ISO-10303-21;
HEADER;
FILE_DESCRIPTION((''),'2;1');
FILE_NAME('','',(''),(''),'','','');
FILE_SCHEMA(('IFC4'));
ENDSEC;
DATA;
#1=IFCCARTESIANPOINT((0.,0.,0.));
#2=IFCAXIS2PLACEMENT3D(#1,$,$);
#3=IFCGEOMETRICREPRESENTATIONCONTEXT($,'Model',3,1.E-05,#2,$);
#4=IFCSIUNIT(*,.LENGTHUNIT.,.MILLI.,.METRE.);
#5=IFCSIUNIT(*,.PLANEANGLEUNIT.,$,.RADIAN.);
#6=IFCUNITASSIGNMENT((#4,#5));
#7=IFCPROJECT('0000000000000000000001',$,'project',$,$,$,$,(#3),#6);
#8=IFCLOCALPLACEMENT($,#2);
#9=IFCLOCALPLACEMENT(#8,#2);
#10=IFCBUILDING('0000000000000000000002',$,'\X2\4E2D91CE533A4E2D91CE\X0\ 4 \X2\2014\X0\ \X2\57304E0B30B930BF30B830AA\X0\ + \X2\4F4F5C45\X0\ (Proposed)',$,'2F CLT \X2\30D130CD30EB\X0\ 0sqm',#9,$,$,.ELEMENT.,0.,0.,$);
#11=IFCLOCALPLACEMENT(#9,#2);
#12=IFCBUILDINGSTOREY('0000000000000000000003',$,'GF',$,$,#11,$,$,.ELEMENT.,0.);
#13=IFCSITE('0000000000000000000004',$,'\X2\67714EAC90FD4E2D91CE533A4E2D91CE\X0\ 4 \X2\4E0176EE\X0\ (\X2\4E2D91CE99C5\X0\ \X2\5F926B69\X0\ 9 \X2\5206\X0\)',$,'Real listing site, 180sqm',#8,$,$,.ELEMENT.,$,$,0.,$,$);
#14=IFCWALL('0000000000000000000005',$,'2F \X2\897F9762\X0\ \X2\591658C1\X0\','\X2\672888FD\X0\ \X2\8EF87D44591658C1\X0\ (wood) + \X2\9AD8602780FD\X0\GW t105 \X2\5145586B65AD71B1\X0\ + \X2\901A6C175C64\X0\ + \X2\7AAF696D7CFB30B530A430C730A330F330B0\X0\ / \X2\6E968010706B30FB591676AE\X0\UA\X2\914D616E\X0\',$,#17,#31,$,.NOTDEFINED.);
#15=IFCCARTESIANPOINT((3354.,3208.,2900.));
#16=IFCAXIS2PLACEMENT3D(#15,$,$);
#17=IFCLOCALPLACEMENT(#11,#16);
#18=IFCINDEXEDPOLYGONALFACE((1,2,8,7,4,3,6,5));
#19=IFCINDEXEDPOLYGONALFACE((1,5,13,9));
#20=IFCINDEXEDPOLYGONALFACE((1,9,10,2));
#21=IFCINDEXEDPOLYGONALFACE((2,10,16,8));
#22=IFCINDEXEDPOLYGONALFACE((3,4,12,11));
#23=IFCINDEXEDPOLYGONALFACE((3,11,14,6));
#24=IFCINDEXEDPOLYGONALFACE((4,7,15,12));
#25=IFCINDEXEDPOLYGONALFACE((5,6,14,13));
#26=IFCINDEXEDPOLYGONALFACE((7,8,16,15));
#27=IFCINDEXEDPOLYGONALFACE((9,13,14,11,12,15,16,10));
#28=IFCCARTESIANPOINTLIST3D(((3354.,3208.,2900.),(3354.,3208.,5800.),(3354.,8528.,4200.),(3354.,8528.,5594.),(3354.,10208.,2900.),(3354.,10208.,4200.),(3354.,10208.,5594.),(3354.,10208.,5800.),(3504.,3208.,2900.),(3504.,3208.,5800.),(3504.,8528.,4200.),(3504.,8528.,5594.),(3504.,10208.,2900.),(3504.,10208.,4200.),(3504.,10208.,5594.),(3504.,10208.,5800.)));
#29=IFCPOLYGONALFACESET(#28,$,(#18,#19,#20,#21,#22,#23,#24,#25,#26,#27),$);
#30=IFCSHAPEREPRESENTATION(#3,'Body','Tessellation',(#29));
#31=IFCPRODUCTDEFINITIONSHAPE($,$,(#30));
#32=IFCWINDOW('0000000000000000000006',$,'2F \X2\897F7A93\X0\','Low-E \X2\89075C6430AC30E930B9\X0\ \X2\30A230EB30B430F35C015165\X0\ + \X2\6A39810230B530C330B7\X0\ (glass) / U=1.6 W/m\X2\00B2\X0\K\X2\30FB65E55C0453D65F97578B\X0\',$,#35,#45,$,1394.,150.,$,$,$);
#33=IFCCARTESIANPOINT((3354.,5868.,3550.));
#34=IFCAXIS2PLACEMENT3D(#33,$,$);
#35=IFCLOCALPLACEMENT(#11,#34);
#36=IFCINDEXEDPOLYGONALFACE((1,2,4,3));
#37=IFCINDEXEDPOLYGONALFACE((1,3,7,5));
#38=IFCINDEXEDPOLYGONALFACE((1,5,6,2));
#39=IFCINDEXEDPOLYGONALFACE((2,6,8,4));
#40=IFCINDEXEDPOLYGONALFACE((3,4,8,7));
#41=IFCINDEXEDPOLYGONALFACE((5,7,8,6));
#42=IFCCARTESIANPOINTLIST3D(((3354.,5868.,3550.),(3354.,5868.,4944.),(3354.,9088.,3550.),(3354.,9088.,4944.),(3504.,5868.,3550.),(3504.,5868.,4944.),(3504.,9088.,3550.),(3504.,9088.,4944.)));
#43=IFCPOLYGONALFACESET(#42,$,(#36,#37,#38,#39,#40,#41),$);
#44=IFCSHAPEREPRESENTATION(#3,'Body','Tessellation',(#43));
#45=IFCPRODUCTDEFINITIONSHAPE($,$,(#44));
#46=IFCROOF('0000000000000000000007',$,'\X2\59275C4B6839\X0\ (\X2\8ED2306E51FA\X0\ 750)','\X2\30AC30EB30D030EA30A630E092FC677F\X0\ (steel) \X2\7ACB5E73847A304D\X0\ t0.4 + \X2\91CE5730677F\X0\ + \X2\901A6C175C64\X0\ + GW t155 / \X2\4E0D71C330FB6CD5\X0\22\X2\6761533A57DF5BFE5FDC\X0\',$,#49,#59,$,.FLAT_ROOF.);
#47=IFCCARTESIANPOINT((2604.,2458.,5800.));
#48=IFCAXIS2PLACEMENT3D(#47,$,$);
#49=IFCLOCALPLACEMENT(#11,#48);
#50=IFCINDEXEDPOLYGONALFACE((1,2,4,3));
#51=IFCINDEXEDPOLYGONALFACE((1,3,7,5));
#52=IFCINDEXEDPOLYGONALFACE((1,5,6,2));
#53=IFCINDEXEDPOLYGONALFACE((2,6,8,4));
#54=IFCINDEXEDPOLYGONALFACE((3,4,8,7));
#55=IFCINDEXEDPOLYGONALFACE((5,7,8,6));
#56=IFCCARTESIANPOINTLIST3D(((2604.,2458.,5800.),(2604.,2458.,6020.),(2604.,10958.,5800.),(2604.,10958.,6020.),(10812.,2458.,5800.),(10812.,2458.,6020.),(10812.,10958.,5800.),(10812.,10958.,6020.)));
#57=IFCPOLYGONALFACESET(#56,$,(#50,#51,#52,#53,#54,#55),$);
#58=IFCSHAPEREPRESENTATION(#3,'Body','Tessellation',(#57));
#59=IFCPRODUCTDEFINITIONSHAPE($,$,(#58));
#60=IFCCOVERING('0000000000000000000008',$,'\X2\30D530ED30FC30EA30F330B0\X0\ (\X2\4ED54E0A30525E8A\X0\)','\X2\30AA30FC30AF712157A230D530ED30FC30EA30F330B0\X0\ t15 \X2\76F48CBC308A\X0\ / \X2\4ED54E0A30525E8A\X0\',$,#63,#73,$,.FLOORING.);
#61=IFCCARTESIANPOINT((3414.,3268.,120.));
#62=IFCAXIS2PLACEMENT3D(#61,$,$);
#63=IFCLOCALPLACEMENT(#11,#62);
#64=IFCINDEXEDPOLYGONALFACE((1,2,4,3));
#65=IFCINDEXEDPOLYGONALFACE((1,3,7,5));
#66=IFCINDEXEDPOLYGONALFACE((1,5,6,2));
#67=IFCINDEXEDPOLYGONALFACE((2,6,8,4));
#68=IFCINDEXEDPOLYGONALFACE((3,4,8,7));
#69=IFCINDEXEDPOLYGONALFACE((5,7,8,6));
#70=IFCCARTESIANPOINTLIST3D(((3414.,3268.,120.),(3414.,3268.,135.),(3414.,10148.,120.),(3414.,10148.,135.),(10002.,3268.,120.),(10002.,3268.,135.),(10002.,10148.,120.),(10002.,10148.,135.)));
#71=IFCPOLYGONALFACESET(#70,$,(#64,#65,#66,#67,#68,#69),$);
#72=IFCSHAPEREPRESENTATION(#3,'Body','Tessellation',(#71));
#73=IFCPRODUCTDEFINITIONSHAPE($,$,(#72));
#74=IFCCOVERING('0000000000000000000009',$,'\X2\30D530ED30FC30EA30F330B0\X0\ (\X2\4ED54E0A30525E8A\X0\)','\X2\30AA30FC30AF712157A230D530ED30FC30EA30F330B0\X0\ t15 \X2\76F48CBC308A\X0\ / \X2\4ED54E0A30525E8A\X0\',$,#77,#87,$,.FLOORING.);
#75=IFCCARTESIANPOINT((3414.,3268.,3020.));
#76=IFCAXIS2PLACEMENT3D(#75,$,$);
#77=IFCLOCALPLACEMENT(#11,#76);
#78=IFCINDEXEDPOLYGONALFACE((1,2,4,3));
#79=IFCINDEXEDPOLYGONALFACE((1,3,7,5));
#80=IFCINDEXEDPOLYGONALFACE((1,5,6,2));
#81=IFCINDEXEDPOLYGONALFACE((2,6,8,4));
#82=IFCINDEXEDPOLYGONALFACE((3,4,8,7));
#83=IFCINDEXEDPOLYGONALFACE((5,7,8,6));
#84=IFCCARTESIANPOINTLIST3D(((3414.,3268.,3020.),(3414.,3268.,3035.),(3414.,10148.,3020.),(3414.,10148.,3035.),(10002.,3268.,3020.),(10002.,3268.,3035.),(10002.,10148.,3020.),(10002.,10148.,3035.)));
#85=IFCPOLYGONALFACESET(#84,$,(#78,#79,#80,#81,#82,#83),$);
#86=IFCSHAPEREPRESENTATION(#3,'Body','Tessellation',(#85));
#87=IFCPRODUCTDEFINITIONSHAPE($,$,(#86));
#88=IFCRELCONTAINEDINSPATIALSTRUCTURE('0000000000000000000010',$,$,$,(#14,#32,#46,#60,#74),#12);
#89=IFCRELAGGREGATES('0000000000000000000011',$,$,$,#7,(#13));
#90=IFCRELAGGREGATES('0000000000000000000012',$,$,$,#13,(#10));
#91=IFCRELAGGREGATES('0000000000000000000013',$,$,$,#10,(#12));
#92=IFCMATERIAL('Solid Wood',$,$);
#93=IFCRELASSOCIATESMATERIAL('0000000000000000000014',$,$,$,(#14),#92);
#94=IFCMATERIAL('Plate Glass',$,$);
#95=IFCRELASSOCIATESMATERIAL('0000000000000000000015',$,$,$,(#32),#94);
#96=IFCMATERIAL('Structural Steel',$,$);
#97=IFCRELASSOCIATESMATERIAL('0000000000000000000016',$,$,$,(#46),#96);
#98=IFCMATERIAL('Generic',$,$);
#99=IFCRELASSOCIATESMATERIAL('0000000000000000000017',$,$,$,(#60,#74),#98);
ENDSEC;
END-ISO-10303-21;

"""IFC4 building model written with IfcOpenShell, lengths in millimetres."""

from ifc_helpers import new_model, si_unit, frame, frame_2d, origin, place, context, project, spatial, rectangle, extrude, material, element, fill, save


model = new_model("IFC4")

# Units and contexts
model_context = context("Model", 3, precision=1e-05, world=origin())
ifc_project = project(units=[si_unit("LENGTHUNIT", "METRE", prefix="MILLI"), si_unit("PLANEANGLEUNIT", "RADIAN")], contexts=[model_context])

# Site, building, storey
site_placement = place(None, origin())
site = spatial("IfcSite", under=ifc_project, at=site_placement, Name="東京都中野区中野 4 丁目 (中野駅 徒歩 9 分)", ObjectType="Real listing site, 180sqm", CompositionType="ELEMENT", RefElevation=0.0)
building_placement = place(site_placement, origin())
building = spatial("IfcBuilding", under=site, at=building_placement, Name="中野区中野 4 — 地下スタジオ + 住居 (Proposed)", ObjectType="2F CLT パネル 0sqm", CompositionType="ELEMENT", ElevationOfRefHeight=0.0, ElevationOfTerrain=0.0)
storey_placement = place(building_placement, origin())
storey = spatial("IfcBuildingStorey", under=building, at=storey_placement, Name="GF", CompositionType="ELEMENT", Elevation=0.0)

# Shared definitions
ifc_material_1 = material(Name="Solid Wood")

# Shared definitions
ifc_material_2 = material(Name="Plate Glass")

# Wall, opening, window
wall_1_placement = place(storey_placement, frame((3354.0, 3208.0, 2900.0)))
wall_1 = element("IfcWall", 1, at=wall_1_placement, inside=storey, material=ifc_material_1, Name="2F 西面 外壁", Description="木製 軸組外壁 (wood) + 高性能GW t105 充填断熱 + 通気層 + 窯業系サイディング / 準耐火・外皮UA配慮", PredefinedType="NOTDEFINED", context=model_context, shape_type="SweptSolid", body=[
    extrude(rectangle(XDim=150.0, YDim=7000.0, at=frame_2d((75.0, 3500.0))), frame((3354.0, 3208.0, 2900.0)), (0.0, 0.0, 1.0), 2900.0),
])
opening_1_placement = place(storey_placement, frame((3354.0, 5868.0, 3550.0)))
opening_1 = element("IfcOpeningElement", 2, at=opening_1_placement, cuts=wall_1, PredefinedType="NOTDEFINED", context=model_context, shape_type="SweptSolid", body=[
    extrude(rectangle(XDim=150.0, YDim=3220.0, at=frame_2d((75.0, 1610.0))), frame((3354.0, 5868.0, 3550.0)), (0.0, 0.0, 1.0), 1394.0),
])
window_1_placement = place(storey_placement, frame((3354.0, 5868.0, 3550.0)))
window_1 = element("IfcWindow", 3, at=window_1_placement, inside=storey, material=ifc_material_2, Name="2F 西窓", Description="Low-E 複層ガラス アルゴン封入 + 樹脂サッシ (glass) / U=1.6 W/m²K・日射取得型", OverallHeight=1394.0, OverallWidth=150.0, context=model_context, shape_type="SweptSolid", body=[
    extrude(rectangle(XDim=150.0, YDim=3220.0, at=frame_2d((75.0, 1610.0))), frame((3354.0, 5868.0, 3550.0)), (0.0, 0.0, 1.0), 1394.0),
])
fill(opening_1, window_1)

# Roof
ifc_material_3 = material(Name="Structural Steel")
roof_placement = place(storey_placement, frame((2604.0, 2458.0, 5800.0)))
element("IfcRoof", 4, at=roof_placement, inside=storey, material=ifc_material_3, Name="大屋根 (軒の出 750)", Description="ガルバリウム鋼板 (steel) 立平葺き t0.4 + 野地板 + 通気層 + GW t155 / 不燃・法22条区域対応", PredefinedType="FLAT_ROOF", context=model_context, shape_type="SweptSolid", body=[
    extrude(rectangle(XDim=8208.0, YDim=8500.0, at=frame_2d((4104.0, 4250.0))), frame((2604.0, 2458.0, 5800.0)), (0.0, 0.0, 1.0), 220.0),
])

# Coverings
ifc_material_4 = material(Name="Generic")
covering_1_placement = place(storey_placement, frame((3414.0, 3268.0, 120.0)))
element("IfcCovering", 5, at=covering_1_placement, inside=storey, material=ifc_material_4, Name="フローリング (仕上げ床)", Description="オーク無垢フローリング t15 直貼り / 仕上げ床", PredefinedType="FLOORING", context=model_context, shape_type="SweptSolid", body=[
    extrude(rectangle(XDim=6588.0, YDim=6880.0, at=frame_2d((3294.0, 3440.0))), frame((3414.0, 3268.0, 120.0)), (0.0, 0.0, 1.0), 15.0),
])
covering_2_placement = place(storey_placement, frame((3414.0, 3268.0, 3020.0)))
element("IfcCovering", 6, at=covering_2_placement, inside=storey, material=ifc_material_4, Name="フローリング (仕上げ床)", Description="オーク無垢フローリング t15 直貼り / 仕上げ床", PredefinedType="FLOORING", context=model_context, shape_type="SweptSolid", body=[
    extrude(rectangle(XDim=6588.0, YDim=6880.0, at=frame_2d((3294.0, 3440.0))), frame((3414.0, 3268.0, 3020.0)), (0.0, 0.0, 1.0), 15.0),
])

save(model, "model.ifc")
